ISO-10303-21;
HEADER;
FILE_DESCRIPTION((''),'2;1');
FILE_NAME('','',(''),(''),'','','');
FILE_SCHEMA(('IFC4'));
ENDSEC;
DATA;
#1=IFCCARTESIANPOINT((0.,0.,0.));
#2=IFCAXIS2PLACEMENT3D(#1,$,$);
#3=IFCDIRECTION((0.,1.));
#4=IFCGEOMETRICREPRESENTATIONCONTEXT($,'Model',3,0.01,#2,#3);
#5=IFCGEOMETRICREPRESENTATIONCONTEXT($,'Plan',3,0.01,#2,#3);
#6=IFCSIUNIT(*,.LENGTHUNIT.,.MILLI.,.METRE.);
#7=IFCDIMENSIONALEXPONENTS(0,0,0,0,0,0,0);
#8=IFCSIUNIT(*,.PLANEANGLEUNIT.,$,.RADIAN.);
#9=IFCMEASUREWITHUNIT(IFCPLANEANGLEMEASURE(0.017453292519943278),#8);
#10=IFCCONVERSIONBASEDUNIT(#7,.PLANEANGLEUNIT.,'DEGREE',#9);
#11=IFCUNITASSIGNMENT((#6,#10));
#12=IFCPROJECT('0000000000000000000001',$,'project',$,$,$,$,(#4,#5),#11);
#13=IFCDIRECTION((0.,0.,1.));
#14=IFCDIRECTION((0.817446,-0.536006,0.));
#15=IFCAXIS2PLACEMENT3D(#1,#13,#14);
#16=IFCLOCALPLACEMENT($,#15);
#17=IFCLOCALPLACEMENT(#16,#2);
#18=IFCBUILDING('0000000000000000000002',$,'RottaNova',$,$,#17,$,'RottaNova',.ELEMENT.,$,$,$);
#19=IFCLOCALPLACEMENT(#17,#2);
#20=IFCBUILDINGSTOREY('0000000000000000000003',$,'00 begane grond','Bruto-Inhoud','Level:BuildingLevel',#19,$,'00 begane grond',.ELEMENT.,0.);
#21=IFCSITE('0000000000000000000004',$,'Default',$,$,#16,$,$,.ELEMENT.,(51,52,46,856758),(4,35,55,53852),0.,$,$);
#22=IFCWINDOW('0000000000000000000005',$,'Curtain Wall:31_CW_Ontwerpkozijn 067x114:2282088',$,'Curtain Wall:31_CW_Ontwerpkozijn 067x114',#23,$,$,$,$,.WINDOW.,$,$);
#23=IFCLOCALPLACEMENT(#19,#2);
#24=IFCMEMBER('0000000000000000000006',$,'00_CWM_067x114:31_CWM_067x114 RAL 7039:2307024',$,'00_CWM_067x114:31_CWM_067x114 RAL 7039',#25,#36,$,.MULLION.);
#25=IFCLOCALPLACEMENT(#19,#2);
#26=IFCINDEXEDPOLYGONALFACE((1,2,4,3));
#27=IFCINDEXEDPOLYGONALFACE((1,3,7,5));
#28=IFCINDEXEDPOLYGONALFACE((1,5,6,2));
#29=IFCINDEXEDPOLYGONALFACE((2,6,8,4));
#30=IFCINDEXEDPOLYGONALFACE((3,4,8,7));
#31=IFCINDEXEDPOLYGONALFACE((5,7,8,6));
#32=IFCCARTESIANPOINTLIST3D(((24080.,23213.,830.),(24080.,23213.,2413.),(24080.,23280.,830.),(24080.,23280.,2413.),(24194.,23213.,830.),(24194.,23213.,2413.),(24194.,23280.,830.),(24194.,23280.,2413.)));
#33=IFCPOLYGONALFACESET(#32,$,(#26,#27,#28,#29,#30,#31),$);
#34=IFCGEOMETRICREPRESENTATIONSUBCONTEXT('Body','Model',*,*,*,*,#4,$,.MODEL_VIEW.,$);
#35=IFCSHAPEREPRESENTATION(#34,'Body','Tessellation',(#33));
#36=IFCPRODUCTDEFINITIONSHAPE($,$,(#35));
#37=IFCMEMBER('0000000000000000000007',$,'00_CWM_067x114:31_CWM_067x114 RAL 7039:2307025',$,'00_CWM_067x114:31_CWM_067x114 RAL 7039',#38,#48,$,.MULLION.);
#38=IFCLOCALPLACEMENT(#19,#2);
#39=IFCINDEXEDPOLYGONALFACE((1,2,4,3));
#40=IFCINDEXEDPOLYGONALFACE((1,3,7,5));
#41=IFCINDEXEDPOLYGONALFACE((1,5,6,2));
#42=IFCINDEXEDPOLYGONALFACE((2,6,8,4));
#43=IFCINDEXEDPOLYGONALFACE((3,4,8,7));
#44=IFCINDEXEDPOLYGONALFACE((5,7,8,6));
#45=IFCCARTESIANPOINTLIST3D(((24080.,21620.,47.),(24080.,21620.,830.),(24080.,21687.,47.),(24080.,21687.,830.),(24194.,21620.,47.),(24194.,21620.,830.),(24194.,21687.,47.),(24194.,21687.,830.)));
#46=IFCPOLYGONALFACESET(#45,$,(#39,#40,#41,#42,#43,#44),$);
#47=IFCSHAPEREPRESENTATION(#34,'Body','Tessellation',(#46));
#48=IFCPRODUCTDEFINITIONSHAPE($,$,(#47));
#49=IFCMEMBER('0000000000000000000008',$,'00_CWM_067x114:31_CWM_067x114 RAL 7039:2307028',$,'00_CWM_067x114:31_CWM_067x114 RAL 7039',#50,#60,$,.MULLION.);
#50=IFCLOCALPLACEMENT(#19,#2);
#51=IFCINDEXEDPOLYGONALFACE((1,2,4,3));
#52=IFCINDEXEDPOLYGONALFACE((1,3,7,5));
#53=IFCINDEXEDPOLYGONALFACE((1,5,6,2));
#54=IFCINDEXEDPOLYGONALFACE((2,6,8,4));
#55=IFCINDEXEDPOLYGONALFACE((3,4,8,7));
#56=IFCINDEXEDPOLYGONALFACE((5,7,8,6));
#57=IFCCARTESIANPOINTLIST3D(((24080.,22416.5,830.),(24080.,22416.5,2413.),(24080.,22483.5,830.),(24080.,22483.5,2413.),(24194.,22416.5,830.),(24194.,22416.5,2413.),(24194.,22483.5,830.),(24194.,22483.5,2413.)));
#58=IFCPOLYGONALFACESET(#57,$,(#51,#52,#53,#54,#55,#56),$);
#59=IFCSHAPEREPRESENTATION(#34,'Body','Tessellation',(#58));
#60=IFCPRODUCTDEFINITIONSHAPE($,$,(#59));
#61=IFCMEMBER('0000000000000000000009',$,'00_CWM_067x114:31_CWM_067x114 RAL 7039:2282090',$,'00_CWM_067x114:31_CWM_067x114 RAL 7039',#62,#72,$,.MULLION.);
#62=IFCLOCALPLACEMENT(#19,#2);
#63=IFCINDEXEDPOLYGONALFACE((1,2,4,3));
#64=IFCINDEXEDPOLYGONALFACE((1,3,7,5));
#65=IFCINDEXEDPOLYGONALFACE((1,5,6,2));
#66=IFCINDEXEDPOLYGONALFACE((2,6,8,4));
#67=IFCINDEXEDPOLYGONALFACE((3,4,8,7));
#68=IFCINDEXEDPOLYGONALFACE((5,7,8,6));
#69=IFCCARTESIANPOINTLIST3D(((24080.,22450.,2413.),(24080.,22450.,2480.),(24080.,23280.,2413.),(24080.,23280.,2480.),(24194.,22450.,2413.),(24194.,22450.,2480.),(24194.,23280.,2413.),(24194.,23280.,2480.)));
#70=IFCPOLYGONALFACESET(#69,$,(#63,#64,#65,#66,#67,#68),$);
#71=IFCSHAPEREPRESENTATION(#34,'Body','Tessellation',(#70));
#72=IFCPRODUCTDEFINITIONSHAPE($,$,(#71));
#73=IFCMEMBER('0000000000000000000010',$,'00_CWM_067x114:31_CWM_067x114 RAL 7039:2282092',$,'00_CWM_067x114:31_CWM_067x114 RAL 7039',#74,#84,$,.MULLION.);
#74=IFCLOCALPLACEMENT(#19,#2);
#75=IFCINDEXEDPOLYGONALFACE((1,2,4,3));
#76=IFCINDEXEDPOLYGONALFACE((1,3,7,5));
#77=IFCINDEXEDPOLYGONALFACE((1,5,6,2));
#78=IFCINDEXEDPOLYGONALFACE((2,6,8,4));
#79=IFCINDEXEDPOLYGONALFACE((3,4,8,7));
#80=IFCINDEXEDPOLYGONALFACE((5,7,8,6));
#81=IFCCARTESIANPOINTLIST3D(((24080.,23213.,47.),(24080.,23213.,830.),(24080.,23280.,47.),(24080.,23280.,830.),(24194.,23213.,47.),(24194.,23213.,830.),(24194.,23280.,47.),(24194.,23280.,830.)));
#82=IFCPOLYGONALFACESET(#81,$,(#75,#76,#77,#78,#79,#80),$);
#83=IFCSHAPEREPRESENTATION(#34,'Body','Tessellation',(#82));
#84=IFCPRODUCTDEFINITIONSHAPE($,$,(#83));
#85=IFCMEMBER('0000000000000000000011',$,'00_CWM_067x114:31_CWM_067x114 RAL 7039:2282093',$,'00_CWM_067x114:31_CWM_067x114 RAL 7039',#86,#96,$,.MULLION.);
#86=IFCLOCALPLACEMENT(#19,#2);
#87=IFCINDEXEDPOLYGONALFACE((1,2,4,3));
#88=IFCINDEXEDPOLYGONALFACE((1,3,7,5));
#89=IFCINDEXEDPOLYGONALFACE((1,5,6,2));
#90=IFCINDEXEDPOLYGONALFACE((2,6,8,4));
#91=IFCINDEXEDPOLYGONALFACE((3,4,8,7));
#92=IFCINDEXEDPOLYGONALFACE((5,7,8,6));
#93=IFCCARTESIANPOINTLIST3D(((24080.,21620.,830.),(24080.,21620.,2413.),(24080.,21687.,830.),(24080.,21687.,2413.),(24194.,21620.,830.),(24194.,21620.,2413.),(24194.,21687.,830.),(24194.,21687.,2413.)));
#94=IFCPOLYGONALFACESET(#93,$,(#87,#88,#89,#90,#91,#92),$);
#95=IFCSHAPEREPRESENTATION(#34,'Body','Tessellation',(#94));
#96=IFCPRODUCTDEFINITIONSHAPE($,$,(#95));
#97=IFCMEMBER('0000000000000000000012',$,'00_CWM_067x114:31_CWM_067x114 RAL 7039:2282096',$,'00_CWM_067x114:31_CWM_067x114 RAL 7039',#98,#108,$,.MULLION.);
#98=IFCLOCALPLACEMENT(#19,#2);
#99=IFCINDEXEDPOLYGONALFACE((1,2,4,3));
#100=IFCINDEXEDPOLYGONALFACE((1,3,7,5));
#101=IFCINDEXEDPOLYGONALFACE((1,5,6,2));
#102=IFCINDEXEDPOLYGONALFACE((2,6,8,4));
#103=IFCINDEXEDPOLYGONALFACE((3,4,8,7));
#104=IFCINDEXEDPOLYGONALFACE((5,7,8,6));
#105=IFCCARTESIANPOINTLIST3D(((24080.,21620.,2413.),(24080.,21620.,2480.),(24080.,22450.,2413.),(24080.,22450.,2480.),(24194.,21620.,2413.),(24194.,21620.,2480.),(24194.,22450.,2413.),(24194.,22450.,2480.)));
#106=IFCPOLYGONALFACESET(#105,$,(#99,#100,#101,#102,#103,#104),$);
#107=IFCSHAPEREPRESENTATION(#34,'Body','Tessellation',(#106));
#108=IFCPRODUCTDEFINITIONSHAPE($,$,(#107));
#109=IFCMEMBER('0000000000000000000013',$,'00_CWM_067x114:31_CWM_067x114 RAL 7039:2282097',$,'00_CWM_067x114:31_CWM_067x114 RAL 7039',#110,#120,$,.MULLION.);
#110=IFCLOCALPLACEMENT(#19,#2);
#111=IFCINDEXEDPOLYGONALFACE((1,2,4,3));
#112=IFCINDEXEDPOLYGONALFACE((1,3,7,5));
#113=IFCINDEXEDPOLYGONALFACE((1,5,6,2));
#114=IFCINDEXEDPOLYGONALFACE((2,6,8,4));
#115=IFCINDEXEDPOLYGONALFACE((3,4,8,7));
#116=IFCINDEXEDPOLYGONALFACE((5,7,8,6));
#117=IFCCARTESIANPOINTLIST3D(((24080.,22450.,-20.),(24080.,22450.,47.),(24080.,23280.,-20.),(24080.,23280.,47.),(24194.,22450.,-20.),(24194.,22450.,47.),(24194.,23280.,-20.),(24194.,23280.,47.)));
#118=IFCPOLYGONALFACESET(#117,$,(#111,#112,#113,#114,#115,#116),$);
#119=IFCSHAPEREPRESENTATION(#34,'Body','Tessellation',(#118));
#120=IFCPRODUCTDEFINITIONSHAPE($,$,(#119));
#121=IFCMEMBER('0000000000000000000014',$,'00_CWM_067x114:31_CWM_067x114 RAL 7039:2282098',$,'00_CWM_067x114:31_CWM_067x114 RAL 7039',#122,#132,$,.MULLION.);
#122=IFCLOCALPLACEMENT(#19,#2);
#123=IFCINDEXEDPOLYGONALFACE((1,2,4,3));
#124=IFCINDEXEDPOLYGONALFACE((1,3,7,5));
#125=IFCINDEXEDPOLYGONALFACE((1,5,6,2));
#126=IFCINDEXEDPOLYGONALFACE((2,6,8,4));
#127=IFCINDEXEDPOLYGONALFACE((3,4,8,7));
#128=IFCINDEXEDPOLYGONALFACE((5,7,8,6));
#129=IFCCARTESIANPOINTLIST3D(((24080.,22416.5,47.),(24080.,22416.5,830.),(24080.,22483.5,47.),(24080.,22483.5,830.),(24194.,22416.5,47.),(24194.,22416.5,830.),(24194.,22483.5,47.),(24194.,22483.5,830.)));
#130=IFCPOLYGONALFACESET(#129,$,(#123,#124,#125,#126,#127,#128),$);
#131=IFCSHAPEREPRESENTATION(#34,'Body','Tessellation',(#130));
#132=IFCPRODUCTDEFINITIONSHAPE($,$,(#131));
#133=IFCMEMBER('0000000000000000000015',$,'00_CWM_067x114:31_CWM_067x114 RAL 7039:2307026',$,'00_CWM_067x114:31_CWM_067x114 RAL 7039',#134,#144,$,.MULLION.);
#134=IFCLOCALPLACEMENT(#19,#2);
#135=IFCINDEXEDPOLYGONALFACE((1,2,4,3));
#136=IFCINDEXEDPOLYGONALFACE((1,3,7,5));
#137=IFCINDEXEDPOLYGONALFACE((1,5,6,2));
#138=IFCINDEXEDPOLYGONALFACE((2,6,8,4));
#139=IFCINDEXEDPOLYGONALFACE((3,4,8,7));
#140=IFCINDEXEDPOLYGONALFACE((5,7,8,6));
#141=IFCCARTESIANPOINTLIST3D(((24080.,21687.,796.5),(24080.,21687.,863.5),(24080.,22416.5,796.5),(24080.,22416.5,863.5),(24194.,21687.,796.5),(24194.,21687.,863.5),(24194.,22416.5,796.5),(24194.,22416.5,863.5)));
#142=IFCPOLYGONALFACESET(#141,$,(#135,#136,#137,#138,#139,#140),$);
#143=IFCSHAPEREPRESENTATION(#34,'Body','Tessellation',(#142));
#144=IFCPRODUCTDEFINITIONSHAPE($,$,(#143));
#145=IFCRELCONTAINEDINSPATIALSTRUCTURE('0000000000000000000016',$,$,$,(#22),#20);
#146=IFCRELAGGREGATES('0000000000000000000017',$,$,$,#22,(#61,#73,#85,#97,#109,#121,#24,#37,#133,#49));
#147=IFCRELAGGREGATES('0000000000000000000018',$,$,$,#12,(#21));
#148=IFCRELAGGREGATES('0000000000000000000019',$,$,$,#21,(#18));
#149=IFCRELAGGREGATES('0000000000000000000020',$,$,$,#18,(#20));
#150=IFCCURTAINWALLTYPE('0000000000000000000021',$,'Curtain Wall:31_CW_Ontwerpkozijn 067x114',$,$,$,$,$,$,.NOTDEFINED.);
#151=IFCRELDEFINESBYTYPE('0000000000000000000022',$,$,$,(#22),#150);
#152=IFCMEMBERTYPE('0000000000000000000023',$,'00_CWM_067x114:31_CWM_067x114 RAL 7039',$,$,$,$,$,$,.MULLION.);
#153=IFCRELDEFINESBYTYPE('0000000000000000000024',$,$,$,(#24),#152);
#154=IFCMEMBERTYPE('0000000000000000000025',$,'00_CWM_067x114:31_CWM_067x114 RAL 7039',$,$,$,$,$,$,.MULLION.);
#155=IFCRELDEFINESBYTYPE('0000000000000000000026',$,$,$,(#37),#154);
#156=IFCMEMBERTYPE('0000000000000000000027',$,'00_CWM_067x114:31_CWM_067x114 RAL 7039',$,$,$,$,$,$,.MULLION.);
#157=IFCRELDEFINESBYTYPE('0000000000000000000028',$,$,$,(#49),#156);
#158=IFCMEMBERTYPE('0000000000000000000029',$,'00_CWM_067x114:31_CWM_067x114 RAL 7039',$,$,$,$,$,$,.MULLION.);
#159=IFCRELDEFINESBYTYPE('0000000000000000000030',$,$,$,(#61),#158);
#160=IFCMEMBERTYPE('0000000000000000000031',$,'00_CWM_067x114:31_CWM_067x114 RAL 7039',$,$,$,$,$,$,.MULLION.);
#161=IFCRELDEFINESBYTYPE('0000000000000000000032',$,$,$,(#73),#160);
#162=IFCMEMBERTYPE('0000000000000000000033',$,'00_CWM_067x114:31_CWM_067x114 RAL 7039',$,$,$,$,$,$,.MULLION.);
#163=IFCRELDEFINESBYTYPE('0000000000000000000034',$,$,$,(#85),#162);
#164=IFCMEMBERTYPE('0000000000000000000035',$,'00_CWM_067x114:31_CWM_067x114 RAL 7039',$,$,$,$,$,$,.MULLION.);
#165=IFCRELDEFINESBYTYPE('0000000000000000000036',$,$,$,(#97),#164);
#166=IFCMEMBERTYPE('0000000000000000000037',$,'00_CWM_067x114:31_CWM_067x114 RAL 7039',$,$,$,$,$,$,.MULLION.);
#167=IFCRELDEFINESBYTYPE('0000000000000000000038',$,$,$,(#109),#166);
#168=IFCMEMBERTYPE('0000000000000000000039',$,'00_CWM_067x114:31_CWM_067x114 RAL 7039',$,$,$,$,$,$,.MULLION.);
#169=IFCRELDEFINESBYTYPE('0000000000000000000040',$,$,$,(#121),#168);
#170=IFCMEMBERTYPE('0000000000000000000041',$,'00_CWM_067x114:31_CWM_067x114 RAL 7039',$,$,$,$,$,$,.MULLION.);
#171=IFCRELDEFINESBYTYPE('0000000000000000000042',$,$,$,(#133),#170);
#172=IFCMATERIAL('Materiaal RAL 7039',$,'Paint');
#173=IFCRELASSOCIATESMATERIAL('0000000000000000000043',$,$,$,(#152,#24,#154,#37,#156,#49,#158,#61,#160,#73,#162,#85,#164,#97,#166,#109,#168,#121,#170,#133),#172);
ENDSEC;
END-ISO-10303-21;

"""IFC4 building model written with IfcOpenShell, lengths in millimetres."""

from ifc_helpers import new_model, entity, si_unit, converted_unit, direction, frame, origin, place, context, subcontext, project, spatial, indexed_curve, outline, extrude, source, transform, mapped, material, type_object, type_shapes, element, aggregate, save


model = new_model("IFC4")

# Units and contexts
model_context = context("Model", 3, precision=0.01, world=origin(), true_north=direction((0.0, 1.0)))
plan_context = context("Plan", 3, precision=0.01, world=origin(), true_north=direction((0.0, 1.0)))
body_context = subcontext(model_context, "Body", "Model", "MODEL_VIEW")
ifc_project = project(units=[si_unit("LENGTHUNIT", "METRE", prefix="MILLI"), converted_unit("PLANEANGLEUNIT", "DEGREE", entity("IfcPlaneAngleMeasure", 0.017453292519943278), si_unit("PLANEANGLEUNIT", "RADIAN"), dimensions=[0, 0, 0, 0, 0, 0, 0])], contexts=[model_context, plan_context])

# Site, building, storey
site_placement = place(None, frame((0.0, 0.0, 0.0), z_axis=(0.0, 0.0, 1.0), x_axis=(0.817446, -0.536006, 0.0)))
site = spatial("IfcSite", under=ifc_project, at=site_placement, Name="Default", CompositionType="ELEMENT", RefLatitude=(51, 52, 46, 856758), RefLongitude=(4, 35, 55, 53852), RefElevation=0.0)
building_placement = place(site_placement, origin())
building = spatial("IfcBuilding", under=site, at=building_placement, Name="RottaNova", LongName="RottaNova", CompositionType="ELEMENT")
storey_placement = place(building_placement, origin())
storey = spatial("IfcBuildingStorey", under=building, at=storey_placement, Name="00 begane grond", Description="Bruto-Inhoud", ObjectType="Level:BuildingLevel", LongName="00 begane grond", CompositionType="ELEMENT", Elevation=0.0)

# Window, members
curtain_wall_type = type_object("IfcCurtainWallType", Name="Curtain Wall:31_CW_Ontwerpkozijn 067x114", PredefinedType="NOTDEFINED")
window_placement = place(storey_placement, origin())
window = element("IfcWindow", 1, at=window_placement, inside=storey, type_object=curtain_wall_type, Name="Curtain Wall:31_CW_Ontwerpkozijn 067x114:2282088", ObjectType="Curtain Wall:31_CW_Ontwerpkozijn 067x114", PredefinedType="WINDOW")
ifc_material_1 = material(Name="Materiaal RAL 7039", Category="Paint")
member_type_1 = type_object("IfcMemberType", Name="00_CWM_067x114:31_CWM_067x114 RAL 7039", PredefinedType="MULLION", material=ifc_material_1)
shared_shape_1 = source(origin(), body_context, "Body", "SweptSolid", [
    extrude(outline(indexed_curve([(-33.5, -57.0), (33.5, -57.0), (33.5, 57.0), (-33.5, 57.0), (-33.5, -57.0)], self_intersect=False)), frame((-33.5, 57.0, -1583.0), z_axis=(0.0, 0.0, 1.0), x_axis=(-1.0, 0.0, 0.0)), (0.0, 0.0, 1.0), 1583.0),
])
type_shapes(member_type_1, [shared_shape_1])
member_1_placement = place(window_placement, frame((24080.0, 23280.0, 830.0), z_axis=(0.0, 0.0, -1.0), x_axis=(0.0, 1.0, 0.0)))
member_1 = element("IfcMember", 2, at=member_1_placement, type_object=member_type_1, material=ifc_material_1, Name="00_CWM_067x114:31_CWM_067x114 RAL 7039:2307024", ObjectType="00_CWM_067x114:31_CWM_067x114 RAL 7039", PredefinedType="MULLION", context=body_context, shape_type="MappedRepresentation", body=[
    mapped(shared_shape_1, transform((0.0, 0.0, 0.0), scale=1.0)),
])
member_type_2 = type_object("IfcMemberType", Name="00_CWM_067x114:31_CWM_067x114 RAL 7039", PredefinedType="MULLION", material=ifc_material_1)
shared_shape_2 = source(origin(), body_context, "Body", "SweptSolid", [
    extrude(outline(indexed_curve([(-33.5, -57.0), (33.5, -57.0), (33.5, 57.0), (-33.5, 57.0), (-33.5, -57.0)], self_intersect=False)), frame((-33.5, 57.0, -783.0), z_axis=(0.0, 0.0, 1.0), x_axis=(-1.0, 0.0, 0.0)), (0.0, 0.0, 1.0), 783.0),
])
type_shapes(member_type_2, [shared_shape_2])
member_2_placement = place(window_placement, frame((24080.0, 21620.0, 830.0), z_axis=(0.0, 0.0, 1.0), x_axis=(0.0, -1.0, 0.0)))
member_2 = element("IfcMember", 3, at=member_2_placement, type_object=member_type_2, material=ifc_material_1, Name="00_CWM_067x114:31_CWM_067x114 RAL 7039:2307025", ObjectType="00_CWM_067x114:31_CWM_067x114 RAL 7039", PredefinedType="MULLION", context=body_context, shape_type="MappedRepresentation", body=[
    mapped(shared_shape_2, transform((0.0, 0.0, 0.0), scale=1.0)),
])
member_type_3 = type_object("IfcMemberType", Name="00_CWM_067x114:31_CWM_067x114 RAL 7039", PredefinedType="MULLION", material=ifc_material_1)
shared_shape_3 = source(origin(), body_context, "Body", "SweptSolid", [
    extrude(outline(indexed_curve([(-33.5, -57.0), (33.5, -57.0), (33.5, 57.0), (-33.5, 57.0), (-33.5, -57.0)], self_intersect=False)), frame((0.0, 57.0, -1583.0), z_axis=(0.0, 0.0, 1.0), x_axis=(-1.0, 0.0, 0.0)), (0.0, 0.0, 1.0), 1583.0),
])
type_shapes(member_type_3, [shared_shape_3])
member_3_placement = place(window_placement, frame((24080.0, 22450.0, 830.0), z_axis=(0.0, 0.0, -1.0), x_axis=(0.0, 1.0, 0.0)))
member_3 = element("IfcMember", 4, at=member_3_placement, type_object=member_type_3, material=ifc_material_1, Name="00_CWM_067x114:31_CWM_067x114 RAL 7039:2307028", ObjectType="00_CWM_067x114:31_CWM_067x114 RAL 7039", PredefinedType="MULLION", context=body_context, shape_type="MappedRepresentation", body=[
    mapped(shared_shape_3, transform((0.0, 0.0, 0.0), scale=1.0)),
])
member_type_4 = type_object("IfcMemberType", Name="00_CWM_067x114:31_CWM_067x114 RAL 7039", PredefinedType="MULLION", material=ifc_material_1)
shared_shape_4 = source(origin(), body_context, "Body", "SweptSolid", [
    extrude(outline(indexed_curve([(-33.5, -57.0), (33.5, -57.0), (33.5, 57.0), (-33.5, 57.0), (-33.5, -57.0)], self_intersect=False)), frame((-33.5, 57.0, -830.0), z_axis=(0.0, 0.0, 1.0), x_axis=(-1.0, 0.0, 0.0)), (0.0, 0.0, 1.0), 830.0),
])
type_shapes(member_type_4, [shared_shape_4])
member_4_placement = place(window_placement, frame((24080.0, 23280.0, 2480.0), z_axis=(0.0, 1.0, 0.0), x_axis=(0.0, 0.0, 1.0)))
member_4 = element("IfcMember", 5, at=member_4_placement, type_object=member_type_4, material=ifc_material_1, Name="00_CWM_067x114:31_CWM_067x114 RAL 7039:2282090", ObjectType="00_CWM_067x114:31_CWM_067x114 RAL 7039", PredefinedType="MULLION", context=body_context, shape_type="MappedRepresentation", body=[
    mapped(shared_shape_4, transform((0.0, 0.0, 0.0), scale=1.0)),
])
member_type_5 = type_object("IfcMemberType", Name="00_CWM_067x114:31_CWM_067x114 RAL 7039", PredefinedType="MULLION", material=ifc_material_1)
shared_shape_5 = source(origin(), body_context, "Body", "SweptSolid", [
    extrude(outline(indexed_curve([(-33.5, -57.0), (33.5, -57.0), (33.5, 57.0), (-33.5, 57.0), (-33.5, -57.0)], self_intersect=False)), frame((-33.5, 57.0, -783.0), z_axis=(0.0, 0.0, 1.0), x_axis=(-1.0, 0.0, 0.0)), (0.0, 0.0, 1.0), 783.0),
])
type_shapes(member_type_5, [shared_shape_5])
member_5_placement = place(window_placement, frame((24080.0, 23280.0, 47.0), z_axis=(0.0, 0.0, -1.0), x_axis=(0.0, 1.0, 0.0)))
member_5 = element("IfcMember", 6, at=member_5_placement, type_object=member_type_5, material=ifc_material_1, Name="00_CWM_067x114:31_CWM_067x114 RAL 7039:2282092", ObjectType="00_CWM_067x114:31_CWM_067x114 RAL 7039", PredefinedType="MULLION", context=body_context, shape_type="MappedRepresentation", body=[
    mapped(shared_shape_5, transform((0.0, 0.0, 0.0), scale=1.0)),
])
member_type_6 = type_object("IfcMemberType", Name="00_CWM_067x114:31_CWM_067x114 RAL 7039", PredefinedType="MULLION", material=ifc_material_1)
shared_shape_6 = source(origin(), body_context, "Body", "SweptSolid", [
    extrude(outline(indexed_curve([(-33.5, -57.0), (33.5, -57.0), (33.5, 57.0), (-33.5, 57.0), (-33.5, -57.0)], self_intersect=False)), frame((-33.5, 57.0, -1583.0), z_axis=(0.0, 0.0, 1.0), x_axis=(-1.0, 0.0, 0.0)), (0.0, 0.0, 1.0), 1583.0),
])
type_shapes(member_type_6, [shared_shape_6])
member_6_placement = place(window_placement, frame((24080.0, 21620.0, 2413.0), z_axis=(0.0, 0.0, 1.0), x_axis=(0.0, -1.0, 0.0)))
member_6 = element("IfcMember", 7, at=member_6_placement, type_object=member_type_6, material=ifc_material_1, Name="00_CWM_067x114:31_CWM_067x114 RAL 7039:2282093", ObjectType="00_CWM_067x114:31_CWM_067x114 RAL 7039", PredefinedType="MULLION", context=body_context, shape_type="MappedRepresentation", body=[
    mapped(shared_shape_6, transform((0.0, 0.0, 0.0), scale=1.0)),
])
member_type_7 = type_object("IfcMemberType", Name="00_CWM_067x114:31_CWM_067x114 RAL 7039", PredefinedType="MULLION", material=ifc_material_1)
shared_shape_7 = source(origin(), body_context, "Body", "SweptSolid", [
    extrude(outline(indexed_curve([(-33.5, -57.0), (33.5, -57.0), (33.5, 57.0), (-33.5, 57.0), (-33.5, -57.0)], self_intersect=False)), frame((-33.5, 57.0, -830.0), z_axis=(0.0, 0.0, 1.0), x_axis=(-1.0, 0.0, 0.0)), (0.0, 0.0, 1.0), 830.0),
])
type_shapes(member_type_7, [shared_shape_7])
member_7_placement = place(window_placement, frame((24080.0, 22450.0, 2480.0), z_axis=(0.0, 1.0, 0.0), x_axis=(0.0, 0.0, 1.0)))
member_7 = element("IfcMember", 8, at=member_7_placement, type_object=member_type_7, material=ifc_material_1, Name="00_CWM_067x114:31_CWM_067x114 RAL 7039:2282096", ObjectType="00_CWM_067x114:31_CWM_067x114 RAL 7039", PredefinedType="MULLION", context=body_context, shape_type="MappedRepresentation", body=[
    mapped(shared_shape_7, transform((0.0, 0.0, 0.0), scale=1.0)),
])
member_type_8 = type_object("IfcMemberType", Name="00_CWM_067x114:31_CWM_067x114 RAL 7039", PredefinedType="MULLION", material=ifc_material_1)
shared_shape_8 = source(origin(), body_context, "Body", "SweptSolid", [
    extrude(outline(indexed_curve([(-33.5, -57.0), (33.5, -57.0), (33.5, 57.0), (-33.5, 57.0), (-33.5, -57.0)], self_intersect=False)), frame((-33.5, 57.0, -830.0), z_axis=(0.0, 0.0, 1.0), x_axis=(-1.0, 0.0, 0.0)), (0.0, 0.0, 1.0), 830.0),
])
type_shapes(member_type_8, [shared_shape_8])
member_8_placement = place(window_placement, frame((24080.0, 22450.0, -20.0), z_axis=(0.0, -1.0, 0.0), x_axis=(0.0, 0.0, -1.0)))
member_8 = element("IfcMember", 9, at=member_8_placement, type_object=member_type_8, material=ifc_material_1, Name="00_CWM_067x114:31_CWM_067x114 RAL 7039:2282097", ObjectType="00_CWM_067x114:31_CWM_067x114 RAL 7039", PredefinedType="MULLION", context=body_context, shape_type="MappedRepresentation", body=[
    mapped(shared_shape_8, transform((0.0, 0.0, 0.0), scale=1.0)),
])
member_type_9 = type_object("IfcMemberType", Name="00_CWM_067x114:31_CWM_067x114 RAL 7039", PredefinedType="MULLION", material=ifc_material_1)
shared_shape_9 = source(origin(), body_context, "Body", "SweptSolid", [
    extrude(outline(indexed_curve([(-33.5, -57.0), (33.5, -57.0), (33.5, 57.0), (-33.5, 57.0), (-33.5, -57.0)], self_intersect=False)), frame((0.0, 57.0, -783.0), z_axis=(0.0, 0.0, 1.0), x_axis=(-1.0, 0.0, 0.0)), (0.0, 0.0, 1.0), 783.0),
])
type_shapes(member_type_9, [shared_shape_9])
member_9_placement = place(window_placement, frame((24080.0, 22450.0, 47.0), z_axis=(0.0, 0.0, -1.0), x_axis=(0.0, 1.0, 0.0)))
member_9 = element("IfcMember", 10, at=member_9_placement, type_object=member_type_9, material=ifc_material_1, Name="00_CWM_067x114:31_CWM_067x114 RAL 7039:2282098", ObjectType="00_CWM_067x114:31_CWM_067x114 RAL 7039", PredefinedType="MULLION", context=body_context, shape_type="MappedRepresentation", body=[
    mapped(shared_shape_9, transform((0.0, 0.0, 0.0), scale=1.0)),
])
member_type_10 = type_object("IfcMemberType", Name="00_CWM_067x114:31_CWM_067x114 RAL 7039", PredefinedType="MULLION", material=ifc_material_1)
shared_shape_10 = source(origin(), body_context, "Body", "SweptSolid", [
    extrude(outline(indexed_curve([(-33.5, -57.0), (33.5, -57.0), (33.5, 57.0), (-33.5, 57.0), (-33.5, -57.0)], self_intersect=False)), frame((0.0, 57.0, -729.5), z_axis=(0.0, 0.0, 1.0), x_axis=(-1.0, 0.0, 0.0)), (0.0, 0.0, 1.0), 729.5),
])
type_shapes(member_type_10, [shared_shape_10])
member_10_placement = place(window_placement, frame((24080.0, 22416.5, 830.0), z_axis=(0.0, 1.0, 0.0), x_axis=(0.0, 0.0, 1.0)))
member_10 = element("IfcMember", 11, at=member_10_placement, type_object=member_type_10, material=ifc_material_1, Name="00_CWM_067x114:31_CWM_067x114 RAL 7039:2307026", ObjectType="00_CWM_067x114:31_CWM_067x114 RAL 7039", PredefinedType="MULLION", context=body_context, shape_type="MappedRepresentation", body=[
    mapped(shared_shape_10, transform((0.0, 0.0, 0.0), scale=1.0)),
])
aggregate(window, [member_4, member_5, member_6, member_7, member_8, member_9, member_1, member_2, member_10, member_3])

save(model, "model.ifc")
